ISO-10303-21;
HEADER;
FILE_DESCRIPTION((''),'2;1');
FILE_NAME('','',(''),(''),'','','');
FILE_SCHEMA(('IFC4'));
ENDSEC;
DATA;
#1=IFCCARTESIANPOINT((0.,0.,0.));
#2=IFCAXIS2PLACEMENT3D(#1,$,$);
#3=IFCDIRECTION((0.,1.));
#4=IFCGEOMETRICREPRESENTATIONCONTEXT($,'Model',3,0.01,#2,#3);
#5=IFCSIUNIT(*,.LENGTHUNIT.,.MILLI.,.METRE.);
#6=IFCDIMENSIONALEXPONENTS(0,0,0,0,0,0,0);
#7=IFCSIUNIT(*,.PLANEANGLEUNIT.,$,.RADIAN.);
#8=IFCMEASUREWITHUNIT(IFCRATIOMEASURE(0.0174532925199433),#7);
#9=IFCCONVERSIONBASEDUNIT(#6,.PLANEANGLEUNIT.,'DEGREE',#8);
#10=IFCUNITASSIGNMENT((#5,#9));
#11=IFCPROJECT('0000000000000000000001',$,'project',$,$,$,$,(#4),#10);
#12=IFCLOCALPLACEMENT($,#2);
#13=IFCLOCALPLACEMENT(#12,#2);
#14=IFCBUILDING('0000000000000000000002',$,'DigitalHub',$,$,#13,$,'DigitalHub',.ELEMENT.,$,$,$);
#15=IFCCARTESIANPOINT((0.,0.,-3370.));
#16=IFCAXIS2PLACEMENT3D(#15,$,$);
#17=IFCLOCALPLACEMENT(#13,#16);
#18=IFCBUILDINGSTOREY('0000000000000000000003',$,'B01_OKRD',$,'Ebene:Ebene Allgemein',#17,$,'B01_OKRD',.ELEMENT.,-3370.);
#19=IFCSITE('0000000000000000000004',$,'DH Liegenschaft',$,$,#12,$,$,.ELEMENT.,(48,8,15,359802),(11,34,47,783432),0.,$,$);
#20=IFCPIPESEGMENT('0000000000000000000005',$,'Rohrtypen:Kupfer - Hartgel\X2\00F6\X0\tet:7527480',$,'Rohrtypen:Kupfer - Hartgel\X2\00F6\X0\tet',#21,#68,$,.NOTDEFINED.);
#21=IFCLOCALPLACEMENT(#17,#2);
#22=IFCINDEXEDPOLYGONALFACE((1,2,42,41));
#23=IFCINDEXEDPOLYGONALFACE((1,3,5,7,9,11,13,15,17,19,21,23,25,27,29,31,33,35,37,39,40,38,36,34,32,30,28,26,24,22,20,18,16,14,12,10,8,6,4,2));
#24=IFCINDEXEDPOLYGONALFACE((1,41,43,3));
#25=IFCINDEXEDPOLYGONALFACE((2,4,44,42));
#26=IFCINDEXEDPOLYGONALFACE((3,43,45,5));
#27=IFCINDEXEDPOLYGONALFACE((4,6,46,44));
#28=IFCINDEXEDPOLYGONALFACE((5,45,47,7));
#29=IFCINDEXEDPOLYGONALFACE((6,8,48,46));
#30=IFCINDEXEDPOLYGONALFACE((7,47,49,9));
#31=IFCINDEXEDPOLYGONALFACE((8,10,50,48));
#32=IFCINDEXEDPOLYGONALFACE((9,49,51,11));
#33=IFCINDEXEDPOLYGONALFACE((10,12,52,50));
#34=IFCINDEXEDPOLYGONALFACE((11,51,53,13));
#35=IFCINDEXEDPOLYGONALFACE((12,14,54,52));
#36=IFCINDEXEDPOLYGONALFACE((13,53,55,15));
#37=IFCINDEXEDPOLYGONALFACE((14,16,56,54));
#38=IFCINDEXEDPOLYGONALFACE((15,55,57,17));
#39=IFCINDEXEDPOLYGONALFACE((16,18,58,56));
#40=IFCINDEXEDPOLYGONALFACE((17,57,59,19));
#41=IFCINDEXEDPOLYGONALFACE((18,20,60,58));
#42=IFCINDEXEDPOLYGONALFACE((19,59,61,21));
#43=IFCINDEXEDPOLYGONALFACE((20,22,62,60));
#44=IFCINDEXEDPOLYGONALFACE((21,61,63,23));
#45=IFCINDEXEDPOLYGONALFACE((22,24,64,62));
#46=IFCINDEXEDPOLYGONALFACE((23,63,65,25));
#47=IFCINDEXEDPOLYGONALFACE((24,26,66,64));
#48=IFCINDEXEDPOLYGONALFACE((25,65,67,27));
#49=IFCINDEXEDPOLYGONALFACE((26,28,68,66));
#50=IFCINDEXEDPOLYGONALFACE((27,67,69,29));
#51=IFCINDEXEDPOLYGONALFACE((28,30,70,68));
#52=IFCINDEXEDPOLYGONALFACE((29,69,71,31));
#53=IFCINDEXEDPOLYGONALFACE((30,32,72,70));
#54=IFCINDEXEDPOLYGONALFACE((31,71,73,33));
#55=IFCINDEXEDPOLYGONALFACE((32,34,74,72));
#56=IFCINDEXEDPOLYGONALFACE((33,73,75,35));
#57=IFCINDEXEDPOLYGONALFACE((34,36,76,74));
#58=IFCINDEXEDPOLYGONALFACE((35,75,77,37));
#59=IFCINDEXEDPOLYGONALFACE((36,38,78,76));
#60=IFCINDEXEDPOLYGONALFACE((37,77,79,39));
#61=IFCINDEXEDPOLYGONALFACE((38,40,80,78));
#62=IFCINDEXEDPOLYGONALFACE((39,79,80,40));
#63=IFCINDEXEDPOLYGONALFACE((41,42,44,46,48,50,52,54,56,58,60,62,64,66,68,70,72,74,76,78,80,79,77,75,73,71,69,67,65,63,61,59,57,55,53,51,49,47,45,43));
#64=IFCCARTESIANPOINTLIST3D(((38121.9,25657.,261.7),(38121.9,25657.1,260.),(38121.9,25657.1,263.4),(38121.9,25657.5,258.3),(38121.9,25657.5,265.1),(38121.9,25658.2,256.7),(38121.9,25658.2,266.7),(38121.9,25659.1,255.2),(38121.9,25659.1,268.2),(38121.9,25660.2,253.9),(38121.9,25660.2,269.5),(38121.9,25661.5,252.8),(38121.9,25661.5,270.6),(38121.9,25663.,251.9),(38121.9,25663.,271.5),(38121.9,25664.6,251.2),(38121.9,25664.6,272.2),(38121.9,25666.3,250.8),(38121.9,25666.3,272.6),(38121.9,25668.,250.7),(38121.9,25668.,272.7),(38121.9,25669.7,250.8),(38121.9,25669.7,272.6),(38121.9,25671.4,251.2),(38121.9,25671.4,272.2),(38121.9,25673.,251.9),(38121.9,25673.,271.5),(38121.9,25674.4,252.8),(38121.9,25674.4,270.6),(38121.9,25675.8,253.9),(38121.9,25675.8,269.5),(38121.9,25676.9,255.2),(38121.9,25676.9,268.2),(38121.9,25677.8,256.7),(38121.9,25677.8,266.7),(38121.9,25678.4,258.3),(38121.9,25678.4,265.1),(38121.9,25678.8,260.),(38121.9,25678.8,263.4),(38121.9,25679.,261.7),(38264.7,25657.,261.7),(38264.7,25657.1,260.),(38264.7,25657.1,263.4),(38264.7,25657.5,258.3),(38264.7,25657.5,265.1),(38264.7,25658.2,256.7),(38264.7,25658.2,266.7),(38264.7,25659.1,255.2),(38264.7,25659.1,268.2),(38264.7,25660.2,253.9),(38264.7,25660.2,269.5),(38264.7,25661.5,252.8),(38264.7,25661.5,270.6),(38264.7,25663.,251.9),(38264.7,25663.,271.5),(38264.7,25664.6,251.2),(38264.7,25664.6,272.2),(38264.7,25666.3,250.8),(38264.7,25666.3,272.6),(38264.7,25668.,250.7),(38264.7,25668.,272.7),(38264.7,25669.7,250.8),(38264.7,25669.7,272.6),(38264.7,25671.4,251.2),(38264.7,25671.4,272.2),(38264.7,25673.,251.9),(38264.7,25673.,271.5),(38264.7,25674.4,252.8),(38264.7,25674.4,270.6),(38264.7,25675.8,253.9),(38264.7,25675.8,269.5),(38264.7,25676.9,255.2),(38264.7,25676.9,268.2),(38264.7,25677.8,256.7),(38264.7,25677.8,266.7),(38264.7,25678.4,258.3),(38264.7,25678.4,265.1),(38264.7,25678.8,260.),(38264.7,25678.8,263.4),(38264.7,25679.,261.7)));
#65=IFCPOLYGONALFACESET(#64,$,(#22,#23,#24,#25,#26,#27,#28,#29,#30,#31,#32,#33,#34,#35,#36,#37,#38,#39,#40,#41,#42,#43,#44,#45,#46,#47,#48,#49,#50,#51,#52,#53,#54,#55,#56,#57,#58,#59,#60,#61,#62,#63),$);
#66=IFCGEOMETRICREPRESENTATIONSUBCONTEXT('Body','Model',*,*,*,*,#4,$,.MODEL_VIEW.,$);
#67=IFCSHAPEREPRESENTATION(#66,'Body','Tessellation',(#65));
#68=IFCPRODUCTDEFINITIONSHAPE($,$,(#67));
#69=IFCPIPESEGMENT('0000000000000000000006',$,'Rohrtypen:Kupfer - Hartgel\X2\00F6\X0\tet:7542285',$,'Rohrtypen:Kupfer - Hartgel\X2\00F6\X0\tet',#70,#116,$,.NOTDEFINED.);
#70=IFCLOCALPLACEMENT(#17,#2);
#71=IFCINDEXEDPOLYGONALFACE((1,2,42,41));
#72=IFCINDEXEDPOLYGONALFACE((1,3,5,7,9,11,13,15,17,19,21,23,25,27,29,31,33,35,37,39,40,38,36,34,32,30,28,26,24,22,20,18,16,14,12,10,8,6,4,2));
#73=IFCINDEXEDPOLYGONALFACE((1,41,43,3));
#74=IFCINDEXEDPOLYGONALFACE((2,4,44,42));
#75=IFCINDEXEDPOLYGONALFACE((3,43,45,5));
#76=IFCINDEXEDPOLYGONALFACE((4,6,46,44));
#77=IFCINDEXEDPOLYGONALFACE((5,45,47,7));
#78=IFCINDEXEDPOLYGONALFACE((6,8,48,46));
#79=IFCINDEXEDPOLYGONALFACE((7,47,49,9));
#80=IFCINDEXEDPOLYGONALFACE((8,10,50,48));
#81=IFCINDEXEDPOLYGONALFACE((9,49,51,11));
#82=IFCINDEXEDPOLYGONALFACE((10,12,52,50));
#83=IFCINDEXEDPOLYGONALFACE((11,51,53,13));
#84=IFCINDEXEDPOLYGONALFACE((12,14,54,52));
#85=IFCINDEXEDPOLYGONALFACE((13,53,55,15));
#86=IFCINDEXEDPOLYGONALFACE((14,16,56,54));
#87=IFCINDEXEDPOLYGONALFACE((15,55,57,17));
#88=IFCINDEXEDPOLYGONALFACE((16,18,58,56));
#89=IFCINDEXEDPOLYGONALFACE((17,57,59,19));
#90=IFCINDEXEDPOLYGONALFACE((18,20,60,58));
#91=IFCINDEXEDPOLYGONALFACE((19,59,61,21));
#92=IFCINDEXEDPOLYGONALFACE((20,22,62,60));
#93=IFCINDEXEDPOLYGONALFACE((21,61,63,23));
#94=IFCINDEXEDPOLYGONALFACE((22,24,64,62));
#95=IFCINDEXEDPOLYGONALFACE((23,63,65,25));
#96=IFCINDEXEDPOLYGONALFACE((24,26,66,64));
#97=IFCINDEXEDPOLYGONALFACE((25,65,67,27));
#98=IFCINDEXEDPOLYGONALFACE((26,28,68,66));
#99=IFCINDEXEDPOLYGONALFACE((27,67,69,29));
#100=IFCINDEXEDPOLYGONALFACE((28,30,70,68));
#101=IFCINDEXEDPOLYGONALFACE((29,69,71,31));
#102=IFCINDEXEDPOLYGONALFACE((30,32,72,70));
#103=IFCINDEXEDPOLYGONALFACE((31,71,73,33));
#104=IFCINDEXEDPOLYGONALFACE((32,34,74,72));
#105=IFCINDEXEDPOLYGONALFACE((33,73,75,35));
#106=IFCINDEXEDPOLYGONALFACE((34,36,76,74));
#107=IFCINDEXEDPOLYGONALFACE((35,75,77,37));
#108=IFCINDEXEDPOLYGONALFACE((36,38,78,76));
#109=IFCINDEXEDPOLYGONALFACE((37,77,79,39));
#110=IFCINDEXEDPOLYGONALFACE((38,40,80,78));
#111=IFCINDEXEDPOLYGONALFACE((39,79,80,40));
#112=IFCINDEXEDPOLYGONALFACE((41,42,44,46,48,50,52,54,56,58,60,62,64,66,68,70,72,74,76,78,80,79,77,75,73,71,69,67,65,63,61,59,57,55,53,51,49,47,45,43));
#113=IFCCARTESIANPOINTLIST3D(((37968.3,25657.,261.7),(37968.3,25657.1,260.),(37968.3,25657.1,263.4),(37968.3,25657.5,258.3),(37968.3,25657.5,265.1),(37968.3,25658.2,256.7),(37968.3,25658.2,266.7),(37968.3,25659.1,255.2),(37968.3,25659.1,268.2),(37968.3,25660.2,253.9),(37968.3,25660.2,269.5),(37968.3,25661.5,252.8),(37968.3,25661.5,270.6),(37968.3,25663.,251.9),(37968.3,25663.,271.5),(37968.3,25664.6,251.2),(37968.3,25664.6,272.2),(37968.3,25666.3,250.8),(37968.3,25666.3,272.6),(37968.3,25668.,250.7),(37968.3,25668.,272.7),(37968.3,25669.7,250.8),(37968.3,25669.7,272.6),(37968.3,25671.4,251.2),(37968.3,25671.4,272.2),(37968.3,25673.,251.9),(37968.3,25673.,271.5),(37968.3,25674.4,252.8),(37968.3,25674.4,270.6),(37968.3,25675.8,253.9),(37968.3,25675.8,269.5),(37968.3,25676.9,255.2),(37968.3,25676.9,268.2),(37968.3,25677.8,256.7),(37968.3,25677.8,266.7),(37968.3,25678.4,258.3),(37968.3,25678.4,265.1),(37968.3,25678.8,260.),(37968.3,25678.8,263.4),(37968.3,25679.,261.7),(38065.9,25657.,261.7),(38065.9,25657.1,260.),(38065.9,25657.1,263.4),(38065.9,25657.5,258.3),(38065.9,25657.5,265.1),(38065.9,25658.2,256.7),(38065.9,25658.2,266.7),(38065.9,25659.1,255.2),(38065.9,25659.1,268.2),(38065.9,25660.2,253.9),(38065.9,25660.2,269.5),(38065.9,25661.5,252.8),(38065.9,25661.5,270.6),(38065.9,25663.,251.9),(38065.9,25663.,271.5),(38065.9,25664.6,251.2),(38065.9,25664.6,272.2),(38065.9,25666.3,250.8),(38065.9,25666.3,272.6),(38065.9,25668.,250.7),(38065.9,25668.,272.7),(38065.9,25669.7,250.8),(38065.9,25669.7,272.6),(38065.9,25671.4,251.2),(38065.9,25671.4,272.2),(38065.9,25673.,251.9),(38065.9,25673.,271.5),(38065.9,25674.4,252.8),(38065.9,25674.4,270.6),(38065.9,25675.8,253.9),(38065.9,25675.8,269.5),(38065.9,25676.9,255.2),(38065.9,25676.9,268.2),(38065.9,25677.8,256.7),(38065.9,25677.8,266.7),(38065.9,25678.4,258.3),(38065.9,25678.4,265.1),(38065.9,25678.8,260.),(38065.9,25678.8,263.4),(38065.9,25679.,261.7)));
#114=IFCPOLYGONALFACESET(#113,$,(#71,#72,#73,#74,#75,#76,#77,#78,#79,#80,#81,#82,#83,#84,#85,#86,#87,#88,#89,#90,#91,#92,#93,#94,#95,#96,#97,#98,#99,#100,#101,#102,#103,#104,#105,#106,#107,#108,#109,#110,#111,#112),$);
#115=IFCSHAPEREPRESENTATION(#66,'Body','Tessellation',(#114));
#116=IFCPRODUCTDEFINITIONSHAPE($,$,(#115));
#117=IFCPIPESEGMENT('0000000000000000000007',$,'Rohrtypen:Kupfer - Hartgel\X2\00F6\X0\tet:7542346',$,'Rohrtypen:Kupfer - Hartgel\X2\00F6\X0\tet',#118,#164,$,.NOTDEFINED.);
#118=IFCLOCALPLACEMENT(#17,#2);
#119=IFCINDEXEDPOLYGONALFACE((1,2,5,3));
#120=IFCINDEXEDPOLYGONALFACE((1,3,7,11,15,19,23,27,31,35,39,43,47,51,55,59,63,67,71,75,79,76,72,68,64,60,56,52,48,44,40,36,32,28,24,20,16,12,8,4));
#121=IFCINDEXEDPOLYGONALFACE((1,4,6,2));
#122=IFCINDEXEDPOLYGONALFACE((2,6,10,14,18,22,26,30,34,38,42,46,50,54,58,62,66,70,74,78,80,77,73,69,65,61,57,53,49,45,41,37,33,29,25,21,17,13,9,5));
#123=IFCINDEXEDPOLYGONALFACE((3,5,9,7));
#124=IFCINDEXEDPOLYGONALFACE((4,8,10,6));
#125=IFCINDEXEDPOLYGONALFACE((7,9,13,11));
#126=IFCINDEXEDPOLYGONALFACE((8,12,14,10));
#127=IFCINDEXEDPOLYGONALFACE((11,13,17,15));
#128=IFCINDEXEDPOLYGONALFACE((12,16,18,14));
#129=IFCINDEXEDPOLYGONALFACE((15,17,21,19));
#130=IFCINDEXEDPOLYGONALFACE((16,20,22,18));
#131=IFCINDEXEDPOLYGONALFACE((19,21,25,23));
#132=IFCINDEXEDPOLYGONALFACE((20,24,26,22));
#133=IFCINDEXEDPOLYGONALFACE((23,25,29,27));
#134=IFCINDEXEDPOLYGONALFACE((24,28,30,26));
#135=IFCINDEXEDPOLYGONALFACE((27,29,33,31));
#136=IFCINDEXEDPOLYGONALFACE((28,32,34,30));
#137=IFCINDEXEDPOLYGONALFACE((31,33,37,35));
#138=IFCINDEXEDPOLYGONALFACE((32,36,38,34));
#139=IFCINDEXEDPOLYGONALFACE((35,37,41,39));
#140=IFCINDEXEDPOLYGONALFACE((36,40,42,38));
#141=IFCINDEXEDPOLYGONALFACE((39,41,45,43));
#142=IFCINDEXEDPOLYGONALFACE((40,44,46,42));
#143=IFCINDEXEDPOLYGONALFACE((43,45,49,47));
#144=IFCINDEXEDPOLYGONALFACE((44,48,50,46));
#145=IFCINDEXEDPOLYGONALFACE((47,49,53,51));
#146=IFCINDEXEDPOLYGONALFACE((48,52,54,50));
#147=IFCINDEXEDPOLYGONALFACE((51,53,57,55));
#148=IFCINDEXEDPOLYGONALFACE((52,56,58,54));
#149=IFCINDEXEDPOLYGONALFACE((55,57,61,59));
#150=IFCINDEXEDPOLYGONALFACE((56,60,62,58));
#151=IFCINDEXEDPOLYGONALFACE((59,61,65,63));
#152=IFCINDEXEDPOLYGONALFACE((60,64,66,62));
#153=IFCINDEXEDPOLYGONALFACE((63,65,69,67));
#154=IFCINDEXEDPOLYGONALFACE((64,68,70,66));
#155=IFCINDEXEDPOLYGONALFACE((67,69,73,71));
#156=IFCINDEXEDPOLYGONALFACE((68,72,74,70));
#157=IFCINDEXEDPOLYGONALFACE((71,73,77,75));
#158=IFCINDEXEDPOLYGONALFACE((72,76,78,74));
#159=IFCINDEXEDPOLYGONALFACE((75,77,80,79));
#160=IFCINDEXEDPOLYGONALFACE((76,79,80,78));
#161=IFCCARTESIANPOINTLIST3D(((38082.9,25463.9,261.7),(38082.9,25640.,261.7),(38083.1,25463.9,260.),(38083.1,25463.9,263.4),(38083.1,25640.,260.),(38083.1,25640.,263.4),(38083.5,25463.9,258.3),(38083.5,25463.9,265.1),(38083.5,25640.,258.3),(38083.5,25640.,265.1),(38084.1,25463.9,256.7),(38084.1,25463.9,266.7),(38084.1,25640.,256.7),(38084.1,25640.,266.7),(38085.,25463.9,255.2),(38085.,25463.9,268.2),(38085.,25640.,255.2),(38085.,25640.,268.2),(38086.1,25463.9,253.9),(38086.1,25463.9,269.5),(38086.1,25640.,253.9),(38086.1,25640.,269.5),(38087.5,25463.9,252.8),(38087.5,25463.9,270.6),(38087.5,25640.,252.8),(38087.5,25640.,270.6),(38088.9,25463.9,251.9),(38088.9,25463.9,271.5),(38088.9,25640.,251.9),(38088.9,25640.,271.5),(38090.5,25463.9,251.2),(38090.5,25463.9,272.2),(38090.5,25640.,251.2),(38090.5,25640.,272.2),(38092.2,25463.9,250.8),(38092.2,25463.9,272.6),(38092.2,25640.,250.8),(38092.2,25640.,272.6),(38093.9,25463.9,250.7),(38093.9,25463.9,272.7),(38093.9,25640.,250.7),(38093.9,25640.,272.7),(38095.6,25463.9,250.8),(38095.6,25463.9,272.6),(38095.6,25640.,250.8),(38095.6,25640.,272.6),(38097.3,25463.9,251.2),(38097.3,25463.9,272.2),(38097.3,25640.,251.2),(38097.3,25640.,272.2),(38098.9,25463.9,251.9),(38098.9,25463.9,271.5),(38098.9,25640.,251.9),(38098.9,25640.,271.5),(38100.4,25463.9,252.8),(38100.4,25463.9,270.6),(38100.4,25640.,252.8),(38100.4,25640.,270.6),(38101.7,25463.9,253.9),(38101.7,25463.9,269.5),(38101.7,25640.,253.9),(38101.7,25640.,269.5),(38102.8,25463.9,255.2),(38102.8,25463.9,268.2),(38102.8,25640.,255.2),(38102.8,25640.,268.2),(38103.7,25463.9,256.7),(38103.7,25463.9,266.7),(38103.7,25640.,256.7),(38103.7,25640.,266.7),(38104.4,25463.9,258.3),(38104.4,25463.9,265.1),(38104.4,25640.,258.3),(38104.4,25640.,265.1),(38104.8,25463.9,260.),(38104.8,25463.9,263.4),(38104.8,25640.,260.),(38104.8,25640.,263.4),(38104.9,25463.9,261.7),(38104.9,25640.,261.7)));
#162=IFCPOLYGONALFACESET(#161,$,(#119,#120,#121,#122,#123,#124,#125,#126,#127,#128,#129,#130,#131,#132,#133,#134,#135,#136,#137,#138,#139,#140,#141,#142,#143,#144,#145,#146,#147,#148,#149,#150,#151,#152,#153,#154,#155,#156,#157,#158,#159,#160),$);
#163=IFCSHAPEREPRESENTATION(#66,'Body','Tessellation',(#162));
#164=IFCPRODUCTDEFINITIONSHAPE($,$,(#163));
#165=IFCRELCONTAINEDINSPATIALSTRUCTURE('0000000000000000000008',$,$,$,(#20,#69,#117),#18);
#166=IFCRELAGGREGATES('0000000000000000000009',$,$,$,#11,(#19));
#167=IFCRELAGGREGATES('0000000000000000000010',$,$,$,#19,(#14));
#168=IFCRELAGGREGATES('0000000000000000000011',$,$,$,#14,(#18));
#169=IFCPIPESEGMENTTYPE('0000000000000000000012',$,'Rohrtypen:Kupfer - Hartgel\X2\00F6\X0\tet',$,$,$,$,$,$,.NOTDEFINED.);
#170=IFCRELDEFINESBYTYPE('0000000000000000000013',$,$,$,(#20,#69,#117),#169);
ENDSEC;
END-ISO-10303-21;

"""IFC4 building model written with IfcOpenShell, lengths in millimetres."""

from ifc_helpers import new_model, entity, si_unit, converted_unit, direction, frame, origin, place, context, subcontext, project, spatial, indexed_curve, outline, extrude, type_object, element, save


model = new_model("IFC4")

# Units and contexts
model_context = context("Model", 3, precision=0.01, world=origin(), true_north=direction((0.0, 1.0)))
body_context = subcontext(model_context, "Body", "Model", "MODEL_VIEW")
ifc_project = project(units=[si_unit("LENGTHUNIT", "METRE", prefix="MILLI"), converted_unit("PLANEANGLEUNIT", "DEGREE", entity("IfcRatioMeasure", 0.0174532925199433), si_unit("PLANEANGLEUNIT", "RADIAN"), dimensions=[0, 0, 0, 0, 0, 0, 0])], contexts=[model_context])

# Site, building, storey
site_placement = place(None, origin())
site = spatial("IfcSite", under=ifc_project, at=site_placement, Name="DH Liegenschaft", CompositionType="ELEMENT", RefLatitude=(48, 8, 15, 359802), RefLongitude=(11, 34, 47, 783432), RefElevation=0.0)
building_placement = place(site_placement, origin())
building = spatial("IfcBuilding", under=site, at=building_placement, Name="DigitalHub", LongName="DigitalHub", CompositionType="ELEMENT")
storey_placement = place(building_placement, frame((0.0, 0.0, -3370.0)))
storey = spatial("IfcBuildingStorey", under=building, at=storey_placement, Name="B01_OKRD", ObjectType="Ebene:Ebene Allgemein", LongName="B01_OKRD", CompositionType="ELEMENT", Elevation=-3370.0)

# Pipe segments
pipe_segment_type = type_object("IfcPipeSegmentType", Name="Rohrtypen:Kupfer - Hartgelötet", PredefinedType="NOTDEFINED")
pipe_segment_1_placement = place(storey_placement, frame((38121.9, 25655.4, 249.1)))
element("IfcPipeSegment", 1, at=pipe_segment_1_placement, inside=storey, type_object=pipe_segment_type, Name="Rohrtypen:Kupfer - Hartgelötet:7527480", ObjectType="Rohrtypen:Kupfer - Hartgelötet", PredefinedType="NOTDEFINED", context=body_context, shape_type="SweptSolid", body=[
    extrude(outline(indexed_curve([(11.0, 0.0), (10.9, 1.7), (10.5, 3.4), (9.8, 5.0), (8.9, 6.5), (7.8, 7.8), (6.5, 8.9), (5.0, 9.8), (3.4, 10.5), (1.7, 10.9), (0.0, 11.0), (-1.7, 10.9), (-3.4, 10.5), (-5.0, 9.8), (-6.5, 8.9), (-7.8, 7.8), (-8.9, 6.5), (-9.8, 5.0), (-10.5, 3.4), (-10.9, 1.7), (-11.0, 0.0), (-10.9, -1.7), (-10.5, -3.4), (-9.8, -5.0), (-8.9, -6.5), (-7.8, -7.8), (-6.5, -8.9), (-5.0, -9.8), (-3.4, -10.5), (-1.7, -10.9), (0.0, -11.0), (1.7, -10.9), (3.4, -10.5), (5.0, -9.8), (6.5, -8.9), (7.8, -7.8), (8.9, -6.5), (9.8, -5.0), (10.5, -3.4), (10.9, -1.7), (11.0, 0.0)], self_intersect=False)), frame((0.0, 12.6, 12.6), z_axis=(1.0, 0.0, 0.0), x_axis=(0.0, -1.0, 0.0)), (0.0, 0.0, 1.0), 142.8),
])
pipe_segment_2_placement = place(storey_placement, frame((37968.3, 25655.4, 249.1)))
element("IfcPipeSegment", 2, at=pipe_segment_2_placement, inside=storey, type_object=pipe_segment_type, Name="Rohrtypen:Kupfer - Hartgelötet:7542285", ObjectType="Rohrtypen:Kupfer - Hartgelötet", PredefinedType="NOTDEFINED", context=body_context, shape_type="SweptSolid", body=[
    extrude(outline(indexed_curve([(11.0, 0.0), (10.9, 1.7), (10.5, 3.4), (9.8, 5.0), (8.9, 6.5), (7.8, 7.8), (6.5, 8.9), (5.0, 9.8), (3.4, 10.5), (1.7, 10.9), (0.0, 11.0), (-1.7, 10.9), (-3.4, 10.5), (-5.0, 9.8), (-6.5, 8.9), (-7.8, 7.8), (-8.9, 6.5), (-9.8, 5.0), (-10.5, 3.4), (-10.9, 1.7), (-11.0, 0.0), (-10.9, -1.7), (-10.5, -3.4), (-9.8, -5.0), (-8.9, -6.5), (-7.8, -7.8), (-6.5, -8.9), (-5.0, -9.8), (-3.4, -10.5), (-1.7, -10.9), (0.0, -11.0), (1.7, -10.9), (3.4, -10.5), (5.0, -9.8), (6.5, -8.9), (7.8, -7.8), (8.9, -6.5), (9.8, -5.0), (10.5, -3.4), (10.9, -1.7), (11.0, 0.0)], self_intersect=False)), frame((0.0, 12.6, 12.6), z_axis=(1.0, 0.0, 0.0), x_axis=(0.0, -1.0, 0.0)), (0.0, 0.0, 1.0), 97.6),
])
pipe_segment_3_placement = place(storey_placement, frame((38081.3, 25463.9, 249.1)))
element("IfcPipeSegment", 3, at=pipe_segment_3_placement, inside=storey, type_object=pipe_segment_type, Name="Rohrtypen:Kupfer - Hartgelötet:7542346", ObjectType="Rohrtypen:Kupfer - Hartgelötet", PredefinedType="NOTDEFINED", context=body_context, shape_type="SweptSolid", body=[
    extrude(outline(indexed_curve([(11.0, 0.0), (10.9, 1.7), (10.5, 3.4), (9.8, 5.0), (8.9, 6.5), (7.8, 7.8), (6.5, 8.9), (5.0, 9.8), (3.4, 10.5), (1.7, 10.9), (0.0, 11.0), (-1.7, 10.9), (-3.4, 10.5), (-5.0, 9.8), (-6.5, 8.9), (-7.8, 7.8), (-8.9, 6.5), (-9.8, 5.0), (-10.5, 3.4), (-10.9, 1.7), (-11.0, 0.0), (-10.9, -1.7), (-10.5, -3.4), (-9.8, -5.0), (-8.9, -6.5), (-7.8, -7.8), (-6.5, -8.9), (-5.0, -9.8), (-3.4, -10.5), (-1.7, -10.9), (0.0, -11.0), (1.7, -10.9), (3.4, -10.5), (5.0, -9.8), (6.5, -8.9), (7.8, -7.8), (8.9, -6.5), (9.8, -5.0), (10.5, -3.4), (10.9, -1.7), (11.0, 0.0)], self_intersect=False)), frame((12.6, 0.0, 12.6), z_axis=(0.0, 1.0, 0.0), x_axis=(-1.0, 0.0, 0.0)), (0.0, 0.0, 1.0), 176.0),
])

save(model, "model.ifc")
